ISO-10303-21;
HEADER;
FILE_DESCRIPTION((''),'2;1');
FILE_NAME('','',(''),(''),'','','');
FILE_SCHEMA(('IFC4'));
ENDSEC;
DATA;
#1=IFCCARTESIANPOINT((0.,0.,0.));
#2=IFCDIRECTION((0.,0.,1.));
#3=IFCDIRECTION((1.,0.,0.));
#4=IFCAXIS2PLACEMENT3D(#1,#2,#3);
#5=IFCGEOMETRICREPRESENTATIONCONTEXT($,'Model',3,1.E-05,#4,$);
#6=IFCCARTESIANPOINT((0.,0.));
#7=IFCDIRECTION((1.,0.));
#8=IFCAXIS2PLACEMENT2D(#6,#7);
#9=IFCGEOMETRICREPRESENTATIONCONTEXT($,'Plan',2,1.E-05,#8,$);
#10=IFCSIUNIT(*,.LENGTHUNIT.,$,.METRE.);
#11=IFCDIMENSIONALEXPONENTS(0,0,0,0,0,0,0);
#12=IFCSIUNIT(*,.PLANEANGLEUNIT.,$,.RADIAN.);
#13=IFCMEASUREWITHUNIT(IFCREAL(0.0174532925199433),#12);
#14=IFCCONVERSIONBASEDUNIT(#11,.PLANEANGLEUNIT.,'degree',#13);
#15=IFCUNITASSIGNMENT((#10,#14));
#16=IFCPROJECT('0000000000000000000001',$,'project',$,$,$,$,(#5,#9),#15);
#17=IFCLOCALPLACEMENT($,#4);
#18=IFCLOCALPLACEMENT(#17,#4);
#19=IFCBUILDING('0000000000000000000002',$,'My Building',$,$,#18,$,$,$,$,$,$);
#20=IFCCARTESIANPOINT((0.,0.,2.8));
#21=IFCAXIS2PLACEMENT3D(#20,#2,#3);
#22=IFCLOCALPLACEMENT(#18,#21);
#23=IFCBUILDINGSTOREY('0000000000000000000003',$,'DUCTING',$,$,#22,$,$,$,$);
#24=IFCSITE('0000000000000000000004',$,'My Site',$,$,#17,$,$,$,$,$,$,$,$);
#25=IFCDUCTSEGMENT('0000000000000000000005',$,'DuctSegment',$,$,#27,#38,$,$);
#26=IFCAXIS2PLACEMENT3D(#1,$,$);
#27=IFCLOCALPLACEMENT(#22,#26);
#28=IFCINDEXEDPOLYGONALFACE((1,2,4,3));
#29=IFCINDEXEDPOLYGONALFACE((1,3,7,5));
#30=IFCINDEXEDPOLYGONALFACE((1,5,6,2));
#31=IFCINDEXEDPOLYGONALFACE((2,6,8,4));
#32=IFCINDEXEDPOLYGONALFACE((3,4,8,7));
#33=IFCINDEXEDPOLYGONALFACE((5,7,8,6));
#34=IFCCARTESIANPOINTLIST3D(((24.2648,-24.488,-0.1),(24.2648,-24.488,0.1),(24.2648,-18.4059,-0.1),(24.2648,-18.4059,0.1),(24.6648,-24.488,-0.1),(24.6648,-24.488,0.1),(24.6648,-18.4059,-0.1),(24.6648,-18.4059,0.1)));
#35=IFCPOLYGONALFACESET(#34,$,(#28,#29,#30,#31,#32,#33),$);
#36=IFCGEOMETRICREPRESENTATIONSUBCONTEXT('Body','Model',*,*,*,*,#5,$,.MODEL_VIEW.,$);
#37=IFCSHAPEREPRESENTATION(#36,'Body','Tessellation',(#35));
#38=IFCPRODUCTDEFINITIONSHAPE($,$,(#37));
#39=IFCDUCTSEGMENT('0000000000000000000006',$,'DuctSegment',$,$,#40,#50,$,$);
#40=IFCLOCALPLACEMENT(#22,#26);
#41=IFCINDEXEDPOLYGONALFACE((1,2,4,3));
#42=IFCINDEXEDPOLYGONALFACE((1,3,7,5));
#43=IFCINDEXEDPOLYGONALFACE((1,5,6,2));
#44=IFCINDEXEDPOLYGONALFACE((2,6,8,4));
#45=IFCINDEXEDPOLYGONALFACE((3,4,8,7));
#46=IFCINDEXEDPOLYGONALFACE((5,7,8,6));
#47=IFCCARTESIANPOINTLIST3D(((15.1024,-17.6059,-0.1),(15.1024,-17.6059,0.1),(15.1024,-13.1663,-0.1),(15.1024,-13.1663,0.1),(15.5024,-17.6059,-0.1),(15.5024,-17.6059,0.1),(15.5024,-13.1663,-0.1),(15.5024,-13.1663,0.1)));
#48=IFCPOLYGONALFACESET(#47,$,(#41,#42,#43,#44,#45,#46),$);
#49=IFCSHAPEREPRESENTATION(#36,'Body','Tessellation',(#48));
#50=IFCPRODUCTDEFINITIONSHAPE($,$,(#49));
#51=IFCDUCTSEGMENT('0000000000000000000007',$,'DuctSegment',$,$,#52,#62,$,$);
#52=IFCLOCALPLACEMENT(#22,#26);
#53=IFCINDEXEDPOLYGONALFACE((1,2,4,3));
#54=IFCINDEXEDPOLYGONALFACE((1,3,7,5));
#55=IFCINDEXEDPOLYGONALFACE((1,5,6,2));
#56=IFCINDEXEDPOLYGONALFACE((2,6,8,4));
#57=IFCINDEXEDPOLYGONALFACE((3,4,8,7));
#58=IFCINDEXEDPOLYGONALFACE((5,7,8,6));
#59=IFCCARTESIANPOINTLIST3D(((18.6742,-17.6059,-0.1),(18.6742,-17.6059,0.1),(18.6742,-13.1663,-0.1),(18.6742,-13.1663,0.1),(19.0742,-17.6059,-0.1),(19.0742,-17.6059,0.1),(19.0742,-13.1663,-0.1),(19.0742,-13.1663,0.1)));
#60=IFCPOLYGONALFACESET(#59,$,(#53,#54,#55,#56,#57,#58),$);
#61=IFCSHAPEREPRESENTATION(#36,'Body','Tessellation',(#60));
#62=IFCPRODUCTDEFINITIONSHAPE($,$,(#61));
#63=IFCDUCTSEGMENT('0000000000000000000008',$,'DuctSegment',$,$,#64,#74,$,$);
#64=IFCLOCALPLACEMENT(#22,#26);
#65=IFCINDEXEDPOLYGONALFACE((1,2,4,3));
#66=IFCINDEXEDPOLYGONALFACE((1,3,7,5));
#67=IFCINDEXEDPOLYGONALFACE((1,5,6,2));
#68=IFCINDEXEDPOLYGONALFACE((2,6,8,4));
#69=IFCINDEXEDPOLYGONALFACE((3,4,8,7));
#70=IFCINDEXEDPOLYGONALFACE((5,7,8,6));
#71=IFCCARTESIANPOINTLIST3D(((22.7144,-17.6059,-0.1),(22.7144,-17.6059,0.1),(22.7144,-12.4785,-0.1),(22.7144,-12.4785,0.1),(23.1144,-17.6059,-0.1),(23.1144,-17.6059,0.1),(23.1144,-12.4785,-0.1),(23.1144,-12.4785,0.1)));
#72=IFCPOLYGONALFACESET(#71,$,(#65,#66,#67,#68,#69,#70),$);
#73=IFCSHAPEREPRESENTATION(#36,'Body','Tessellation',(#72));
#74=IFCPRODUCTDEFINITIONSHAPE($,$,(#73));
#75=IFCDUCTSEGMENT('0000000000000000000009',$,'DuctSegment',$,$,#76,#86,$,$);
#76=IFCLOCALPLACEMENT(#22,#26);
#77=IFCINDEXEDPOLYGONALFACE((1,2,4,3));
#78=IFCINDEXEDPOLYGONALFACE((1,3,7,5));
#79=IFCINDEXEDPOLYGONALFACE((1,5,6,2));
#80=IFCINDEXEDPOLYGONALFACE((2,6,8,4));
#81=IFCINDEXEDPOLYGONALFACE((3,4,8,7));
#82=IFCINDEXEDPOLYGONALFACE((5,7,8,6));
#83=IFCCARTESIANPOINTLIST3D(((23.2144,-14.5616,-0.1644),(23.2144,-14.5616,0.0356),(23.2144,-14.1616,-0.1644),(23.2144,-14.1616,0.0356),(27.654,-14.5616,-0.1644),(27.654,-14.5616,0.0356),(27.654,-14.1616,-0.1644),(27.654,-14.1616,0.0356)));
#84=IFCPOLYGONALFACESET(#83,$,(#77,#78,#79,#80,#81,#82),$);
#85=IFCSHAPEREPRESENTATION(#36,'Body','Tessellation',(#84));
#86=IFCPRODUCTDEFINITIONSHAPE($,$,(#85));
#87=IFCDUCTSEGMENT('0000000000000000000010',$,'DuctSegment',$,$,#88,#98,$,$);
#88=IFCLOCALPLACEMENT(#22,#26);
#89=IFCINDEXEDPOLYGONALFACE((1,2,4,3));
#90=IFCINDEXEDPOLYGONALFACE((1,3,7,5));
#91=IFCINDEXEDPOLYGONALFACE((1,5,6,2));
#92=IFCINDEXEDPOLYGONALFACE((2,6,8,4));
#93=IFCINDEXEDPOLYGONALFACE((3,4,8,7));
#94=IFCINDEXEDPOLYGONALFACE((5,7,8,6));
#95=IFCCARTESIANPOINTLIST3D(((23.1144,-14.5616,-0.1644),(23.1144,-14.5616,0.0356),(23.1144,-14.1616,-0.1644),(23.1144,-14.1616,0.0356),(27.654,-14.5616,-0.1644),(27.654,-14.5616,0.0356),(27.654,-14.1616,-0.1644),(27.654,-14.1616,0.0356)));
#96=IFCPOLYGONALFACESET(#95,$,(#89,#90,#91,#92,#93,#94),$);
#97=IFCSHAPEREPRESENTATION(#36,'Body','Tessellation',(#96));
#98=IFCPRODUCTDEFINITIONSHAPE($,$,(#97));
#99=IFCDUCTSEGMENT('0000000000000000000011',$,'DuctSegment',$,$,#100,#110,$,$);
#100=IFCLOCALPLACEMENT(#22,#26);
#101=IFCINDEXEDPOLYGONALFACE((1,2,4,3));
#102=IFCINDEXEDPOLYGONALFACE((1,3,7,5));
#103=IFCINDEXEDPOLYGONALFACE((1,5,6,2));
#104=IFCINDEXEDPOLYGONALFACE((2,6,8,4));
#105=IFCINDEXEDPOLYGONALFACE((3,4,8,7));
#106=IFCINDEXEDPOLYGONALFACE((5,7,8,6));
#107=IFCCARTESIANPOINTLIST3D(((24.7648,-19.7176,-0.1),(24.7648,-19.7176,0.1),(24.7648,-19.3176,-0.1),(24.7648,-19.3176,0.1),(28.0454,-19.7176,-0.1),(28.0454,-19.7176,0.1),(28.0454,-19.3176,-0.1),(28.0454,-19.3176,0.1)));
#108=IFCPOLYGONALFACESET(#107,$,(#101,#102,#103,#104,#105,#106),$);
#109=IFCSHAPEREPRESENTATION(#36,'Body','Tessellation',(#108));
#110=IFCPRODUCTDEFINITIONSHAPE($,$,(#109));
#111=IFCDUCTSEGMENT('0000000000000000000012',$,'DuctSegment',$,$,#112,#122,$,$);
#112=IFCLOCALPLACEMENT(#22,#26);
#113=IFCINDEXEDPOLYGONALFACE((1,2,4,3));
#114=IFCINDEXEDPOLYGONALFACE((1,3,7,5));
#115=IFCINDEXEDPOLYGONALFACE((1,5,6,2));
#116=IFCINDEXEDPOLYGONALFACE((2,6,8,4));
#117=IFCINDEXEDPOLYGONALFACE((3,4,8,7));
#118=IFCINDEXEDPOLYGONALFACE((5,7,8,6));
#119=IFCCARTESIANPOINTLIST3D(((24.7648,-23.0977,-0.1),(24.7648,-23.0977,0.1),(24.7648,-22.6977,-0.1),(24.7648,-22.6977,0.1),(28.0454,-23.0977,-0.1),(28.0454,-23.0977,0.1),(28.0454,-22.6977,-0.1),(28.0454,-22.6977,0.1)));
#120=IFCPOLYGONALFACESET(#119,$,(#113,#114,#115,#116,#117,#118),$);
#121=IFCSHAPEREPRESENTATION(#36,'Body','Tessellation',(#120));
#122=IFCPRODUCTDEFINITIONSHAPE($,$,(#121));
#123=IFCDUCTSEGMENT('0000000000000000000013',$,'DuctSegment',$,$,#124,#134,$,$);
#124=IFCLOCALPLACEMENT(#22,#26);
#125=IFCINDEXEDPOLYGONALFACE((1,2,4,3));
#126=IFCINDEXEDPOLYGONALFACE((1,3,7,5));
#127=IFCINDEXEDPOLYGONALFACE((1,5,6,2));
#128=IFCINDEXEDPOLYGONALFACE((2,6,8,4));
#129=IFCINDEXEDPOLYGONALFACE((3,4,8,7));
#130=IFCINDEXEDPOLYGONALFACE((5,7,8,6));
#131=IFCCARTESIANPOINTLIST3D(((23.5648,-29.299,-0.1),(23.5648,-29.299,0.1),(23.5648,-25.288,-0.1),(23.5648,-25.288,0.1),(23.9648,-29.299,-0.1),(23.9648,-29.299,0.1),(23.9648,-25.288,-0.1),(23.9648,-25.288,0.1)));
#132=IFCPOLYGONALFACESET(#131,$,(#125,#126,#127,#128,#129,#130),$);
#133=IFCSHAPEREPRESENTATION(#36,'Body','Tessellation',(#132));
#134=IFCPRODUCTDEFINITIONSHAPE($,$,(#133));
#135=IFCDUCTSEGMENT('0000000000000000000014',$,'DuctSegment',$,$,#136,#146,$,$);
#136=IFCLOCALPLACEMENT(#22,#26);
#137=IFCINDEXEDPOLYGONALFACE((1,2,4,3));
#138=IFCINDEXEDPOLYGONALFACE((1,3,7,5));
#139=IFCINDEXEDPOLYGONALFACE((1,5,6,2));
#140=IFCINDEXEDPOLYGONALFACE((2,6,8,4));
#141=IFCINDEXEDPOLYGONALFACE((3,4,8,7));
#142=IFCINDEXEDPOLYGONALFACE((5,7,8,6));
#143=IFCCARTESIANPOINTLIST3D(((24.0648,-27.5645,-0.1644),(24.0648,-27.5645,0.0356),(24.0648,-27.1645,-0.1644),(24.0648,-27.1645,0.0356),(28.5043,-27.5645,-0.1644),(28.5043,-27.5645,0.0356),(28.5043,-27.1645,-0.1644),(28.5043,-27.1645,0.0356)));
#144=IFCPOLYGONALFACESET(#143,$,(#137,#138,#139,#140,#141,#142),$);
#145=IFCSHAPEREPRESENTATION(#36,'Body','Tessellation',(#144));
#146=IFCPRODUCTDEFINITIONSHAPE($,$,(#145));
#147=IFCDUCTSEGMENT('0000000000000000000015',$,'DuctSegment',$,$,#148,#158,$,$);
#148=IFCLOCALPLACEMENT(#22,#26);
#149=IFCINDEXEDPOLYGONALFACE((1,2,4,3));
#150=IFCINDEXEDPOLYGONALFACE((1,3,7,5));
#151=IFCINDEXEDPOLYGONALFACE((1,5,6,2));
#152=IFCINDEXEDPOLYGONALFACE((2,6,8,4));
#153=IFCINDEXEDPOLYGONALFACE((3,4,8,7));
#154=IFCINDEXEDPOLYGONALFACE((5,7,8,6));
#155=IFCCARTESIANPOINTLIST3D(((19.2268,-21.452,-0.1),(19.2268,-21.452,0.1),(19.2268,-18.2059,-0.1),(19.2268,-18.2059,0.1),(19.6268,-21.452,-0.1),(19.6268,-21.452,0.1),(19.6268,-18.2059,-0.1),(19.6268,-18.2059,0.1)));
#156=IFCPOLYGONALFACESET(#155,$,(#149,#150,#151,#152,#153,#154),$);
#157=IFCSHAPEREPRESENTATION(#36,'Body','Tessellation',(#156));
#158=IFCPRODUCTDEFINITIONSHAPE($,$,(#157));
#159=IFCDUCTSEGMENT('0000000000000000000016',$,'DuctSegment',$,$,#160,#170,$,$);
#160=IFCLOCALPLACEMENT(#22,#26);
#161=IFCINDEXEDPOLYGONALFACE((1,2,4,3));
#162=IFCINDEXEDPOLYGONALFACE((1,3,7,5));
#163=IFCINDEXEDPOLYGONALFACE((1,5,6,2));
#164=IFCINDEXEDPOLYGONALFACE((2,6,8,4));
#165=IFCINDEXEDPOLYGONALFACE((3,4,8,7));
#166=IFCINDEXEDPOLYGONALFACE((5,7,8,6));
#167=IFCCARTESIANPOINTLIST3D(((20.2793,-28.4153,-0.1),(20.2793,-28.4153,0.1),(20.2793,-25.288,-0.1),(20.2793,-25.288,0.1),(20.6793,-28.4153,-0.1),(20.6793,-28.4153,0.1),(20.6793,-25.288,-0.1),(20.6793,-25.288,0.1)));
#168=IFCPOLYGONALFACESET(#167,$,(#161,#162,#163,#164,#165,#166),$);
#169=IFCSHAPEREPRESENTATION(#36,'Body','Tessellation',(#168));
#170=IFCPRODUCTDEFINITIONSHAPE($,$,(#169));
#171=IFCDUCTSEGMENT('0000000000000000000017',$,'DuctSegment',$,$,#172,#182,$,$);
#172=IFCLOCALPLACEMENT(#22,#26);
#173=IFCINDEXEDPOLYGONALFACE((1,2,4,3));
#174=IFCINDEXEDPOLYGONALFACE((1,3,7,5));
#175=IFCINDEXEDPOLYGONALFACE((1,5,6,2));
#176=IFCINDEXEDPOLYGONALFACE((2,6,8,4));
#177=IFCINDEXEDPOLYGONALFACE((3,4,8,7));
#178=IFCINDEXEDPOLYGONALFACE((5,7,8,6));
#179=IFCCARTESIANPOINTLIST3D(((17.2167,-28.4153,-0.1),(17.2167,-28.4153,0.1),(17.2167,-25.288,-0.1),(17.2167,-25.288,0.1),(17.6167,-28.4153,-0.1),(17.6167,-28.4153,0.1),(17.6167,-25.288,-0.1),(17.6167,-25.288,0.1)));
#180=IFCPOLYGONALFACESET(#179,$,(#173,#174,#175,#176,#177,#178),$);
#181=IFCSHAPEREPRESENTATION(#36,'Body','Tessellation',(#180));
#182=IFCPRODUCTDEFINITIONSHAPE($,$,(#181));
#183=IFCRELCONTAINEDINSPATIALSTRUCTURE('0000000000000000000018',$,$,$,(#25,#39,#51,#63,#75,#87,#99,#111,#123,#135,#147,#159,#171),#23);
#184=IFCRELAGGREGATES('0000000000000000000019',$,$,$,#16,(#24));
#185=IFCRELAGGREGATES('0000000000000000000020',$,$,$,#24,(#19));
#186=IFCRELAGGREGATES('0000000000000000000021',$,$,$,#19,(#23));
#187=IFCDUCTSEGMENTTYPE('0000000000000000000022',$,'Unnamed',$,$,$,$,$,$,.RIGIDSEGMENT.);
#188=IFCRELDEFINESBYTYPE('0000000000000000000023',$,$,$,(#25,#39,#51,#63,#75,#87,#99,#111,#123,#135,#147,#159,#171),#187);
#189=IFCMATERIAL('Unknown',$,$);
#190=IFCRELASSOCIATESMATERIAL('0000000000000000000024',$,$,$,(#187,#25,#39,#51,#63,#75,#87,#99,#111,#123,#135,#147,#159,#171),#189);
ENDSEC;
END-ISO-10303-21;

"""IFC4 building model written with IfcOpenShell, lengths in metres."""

from ifc_helpers import new_model, entity, si_unit, converted_unit, frame, origin_with_axes, origin_2d_with_axis, place, context, subcontext, project, spatial, rectangle, extrude, material, material_profile, profile_set, profile_usage, type_object, element, save


model = new_model("IFC4")

# Units and contexts
model_context = context("Model", 3, precision=1e-05, world=origin_with_axes())
plan_context = context("Plan", 2, precision=1e-05, world=origin_2d_with_axis())
body_context = subcontext(model_context, "Body", "Model", "MODEL_VIEW")
ifc_project = project(units=[si_unit("LENGTHUNIT", "METRE"), converted_unit("PLANEANGLEUNIT", "degree", entity("IfcReal", 0.0174532925199433), si_unit("PLANEANGLEUNIT", "RADIAN"), dimensions=[0, 0, 0, 0, 0, 0, 0])], contexts=[model_context, plan_context])

# Site, building, storey
site_placement = place(None, origin_with_axes())
site = spatial("IfcSite", under=ifc_project, at=site_placement, Name="My Site")
building_placement = place(site_placement, origin_with_axes())
building = spatial("IfcBuilding", under=site, at=building_placement, Name="My Building")
storey_placement = place(building_placement, frame((0.0, 0.0, 2.8), z_axis=(0.0, 0.0, 1.0), x_axis=(1.0, 0.0, 0.0)))
storey = spatial("IfcBuildingStorey", under=building, at=storey_placement, Name="DUCTING")

# Duct segments
ifc_material = material(Name="Unknown")
ifc_material_profile_1 = material_profile(ifc_material, rectangle(XDim=0.4, YDim=0.2))
ifc_profile_set_1 = profile_set([ifc_material_profile_1])
ifc_profile_usage_1 = profile_usage(ifc_profile_set_1, cardinal=5)
duct_segment_type = type_object("IfcDuctSegmentType", Name="Unnamed", PredefinedType="RIGIDSEGMENT", material=ifc_profile_set_1)
duct_segment_1_placement = place(storey_placement, frame((24.4648, -18.4059, 0.0), z_axis=(0.0, -1.0, 0.0), x_axis=(-1.0, 0.0, 0.0)))
element("IfcDuctSegment", 1, at=duct_segment_1_placement, inside=storey, type_object=duct_segment_type, material=ifc_profile_usage_1, Name="DuctSegment", context=body_context, shape_type="SweptSolid", body=[
    extrude(rectangle(XDim=0.4, YDim=0.2), origin_with_axes(), (0.0, 0.0, 1.0), 6.0821),
])
ifc_profile_usage_2 = profile_usage(ifc_profile_set_1, cardinal=5)
duct_segment_2_placement = place(storey_placement, frame((15.3024, -13.1663, 0.0), z_axis=(0.0, -1.0, 0.0), x_axis=(-1.0, 0.0, 0.0)))
element("IfcDuctSegment", 2, at=duct_segment_2_placement, inside=storey, type_object=duct_segment_type, material=ifc_profile_usage_2, Name="DuctSegment", context=body_context, shape_type="SweptSolid", body=[
    extrude(rectangle(XDim=0.4, YDim=0.2), origin_with_axes(), (0.0, 0.0, 1.0), 4.4396),
])
ifc_profile_usage_3 = profile_usage(ifc_profile_set_1, cardinal=5)
duct_segment_3_placement = place(storey_placement, frame((18.8742, -13.1663, 0.0), z_axis=(0.0, -1.0, 0.0), x_axis=(-1.0, 0.0, 0.0)))
element("IfcDuctSegment", 3, at=duct_segment_3_placement, inside=storey, type_object=duct_segment_type, material=ifc_profile_usage_3, Name="DuctSegment", context=body_context, shape_type="SweptSolid", body=[
    extrude(rectangle(XDim=0.4, YDim=0.2), origin_with_axes(), (0.0, 0.0, 1.0), 4.4396),
])
ifc_profile_usage_4 = profile_usage(ifc_profile_set_1, cardinal=5)
duct_segment_4_placement = place(storey_placement, frame((22.9144, -12.4785, 0.0), z_axis=(0.0, -1.0, 0.0), x_axis=(-1.0, 0.0, 0.0)))
element("IfcDuctSegment", 4, at=duct_segment_4_placement, inside=storey, type_object=duct_segment_type, material=ifc_profile_usage_4, Name="DuctSegment", context=body_context, shape_type="SweptSolid", body=[
    extrude(rectangle(XDim=0.4, YDim=0.2), origin_with_axes(), (0.0, 0.0, 1.0), 5.1273),
])
ifc_profile_usage_5 = profile_usage(ifc_profile_set_1, cardinal=5)
duct_segment_5_placement = place(storey_placement, frame((27.654, -14.3616, -0.0644), z_axis=(-1.0, 0.0, 0.0), x_axis=(0.0, 1.0, 0.0)))
element("IfcDuctSegment", 5, at=duct_segment_5_placement, inside=storey, type_object=duct_segment_type, material=ifc_profile_usage_5, Name="DuctSegment", context=body_context, shape_type="SweptSolid", body=[
    extrude(rectangle(XDim=0.4, YDim=0.2), origin_with_axes(), (0.0, 0.0, 1.0), 4.4396),
])
ifc_profile_usage_6 = profile_usage(ifc_profile_set_1, cardinal=5)
duct_segment_6_placement = place(storey_placement, frame((27.654, -14.3616, -0.0644), z_axis=(-1.0, 0.0, 0.0), x_axis=(0.0, 1.0, 0.0)))
element("IfcDuctSegment", 6, at=duct_segment_6_placement, inside=storey, type_object=duct_segment_type, material=ifc_profile_usage_6, Name="DuctSegment", context=body_context, shape_type="SweptSolid", body=[
    extrude(rectangle(XDim=0.4, YDim=0.2), origin_with_axes(), (0.0, 0.0, 1.0), 4.5396),
])
ifc_profile_usage_7 = profile_usage(ifc_profile_set_1, cardinal=5)
duct_segment_7_placement = place(storey_placement, frame((28.0454, -19.5176, 0.0), z_axis=(-1.0, 0.0, 0.0), x_axis=(0.0, 1.0, 0.0)))
element("IfcDuctSegment", 7, at=duct_segment_7_placement, inside=storey, type_object=duct_segment_type, material=ifc_profile_usage_7, Name="DuctSegment", context=body_context, shape_type="SweptSolid", body=[
    extrude(rectangle(XDim=0.4, YDim=0.2), origin_with_axes(), (0.0, 0.0, 1.0), 3.2806),
])
ifc_profile_usage_8 = profile_usage(ifc_profile_set_1, cardinal=5)
duct_segment_8_placement = place(storey_placement, frame((28.0454, -22.8977, 0.0), z_axis=(-1.0, 0.0, 0.0), x_axis=(0.0, 1.0, 0.0)))
element("IfcDuctSegment", 8, at=duct_segment_8_placement, inside=storey, type_object=duct_segment_type, material=ifc_profile_usage_8, Name="DuctSegment", context=body_context, shape_type="SweptSolid", body=[
    extrude(rectangle(XDim=0.4, YDim=0.2), origin_with_axes(), (0.0, 0.0, 1.0), 3.2806),
])
ifc_profile_usage_9 = profile_usage(ifc_profile_set_1, cardinal=5)
duct_segment_9_placement = place(storey_placement, frame((23.7648, -29.299, 0.0), z_axis=(0.0, 1.0, 0.0), x_axis=(1.0, 0.0, 0.0)))
element("IfcDuctSegment", 9, at=duct_segment_9_placement, inside=storey, type_object=duct_segment_type, material=ifc_profile_usage_9, Name="DuctSegment", context=body_context, shape_type="SweptSolid", body=[
    extrude(rectangle(XDim=0.4, YDim=0.2), origin_with_axes(), (0.0, 0.0, 1.0), 4.011),
])
ifc_profile_usage_10 = profile_usage(ifc_profile_set_1, cardinal=5)
duct_segment_10_placement = place(storey_placement, frame((28.5043, -27.3645, -0.0644), z_axis=(-1.0, 0.0, 0.0), x_axis=(0.0, 1.0, 0.0)))
element("IfcDuctSegment", 10, at=duct_segment_10_placement, inside=storey, type_object=duct_segment_type, material=ifc_profile_usage_10, Name="DuctSegment", context=body_context, shape_type="SweptSolid", body=[
    extrude(rectangle(XDim=0.4, YDim=0.2), origin_with_axes(), (0.0, 0.0, 1.0), 4.4396),
])
ifc_profile_usage_11 = profile_usage(ifc_profile_set_1, cardinal=5)
duct_segment_11_placement = place(storey_placement, frame((19.4268, -21.452, 0.0), z_axis=(0.0, 1.0, 0.0), x_axis=(1.0, 0.0, 0.0)))
element("IfcDuctSegment", 11, at=duct_segment_11_placement, inside=storey, type_object=duct_segment_type, material=ifc_profile_usage_11, Name="DuctSegment", context=body_context, shape_type="SweptSolid", body=[
    extrude(rectangle(XDim=0.4, YDim=0.2), origin_with_axes(), (0.0, 0.0, 1.0), 3.2461),
])
ifc_profile_usage_12 = profile_usage(ifc_profile_set_1, cardinal=5)
duct_segment_12_placement = place(storey_placement, frame((20.4793, -28.4153, 0.0), z_axis=(0.0, 1.0, 0.0), x_axis=(1.0, 0.0, 0.0)))
element("IfcDuctSegment", 12, at=duct_segment_12_placement, inside=storey, type_object=duct_segment_type, material=ifc_profile_usage_12, Name="DuctSegment", context=body_context, shape_type="SweptSolid", body=[
    extrude(rectangle(XDim=0.4, YDim=0.2), origin_with_axes(), (0.0, 0.0, 1.0), 3.1273),
])
ifc_profile_usage_13 = profile_usage(ifc_profile_set_1, cardinal=5)
duct_segment_13_placement = place(storey_placement, frame((17.4167, -28.4153, 0.0), z_axis=(0.0, 1.0, 0.0), x_axis=(1.0, 0.0, 0.0)))
element("IfcDuctSegment", 13, at=duct_segment_13_placement, inside=storey, type_object=duct_segment_type, material=ifc_profile_usage_13, Name="DuctSegment", context=body_context, shape_type="SweptSolid", body=[
    extrude(rectangle(XDim=0.4, YDim=0.2), origin_with_axes(), (0.0, 0.0, 1.0), 3.1273),
])

save(model, "model.ifc")
